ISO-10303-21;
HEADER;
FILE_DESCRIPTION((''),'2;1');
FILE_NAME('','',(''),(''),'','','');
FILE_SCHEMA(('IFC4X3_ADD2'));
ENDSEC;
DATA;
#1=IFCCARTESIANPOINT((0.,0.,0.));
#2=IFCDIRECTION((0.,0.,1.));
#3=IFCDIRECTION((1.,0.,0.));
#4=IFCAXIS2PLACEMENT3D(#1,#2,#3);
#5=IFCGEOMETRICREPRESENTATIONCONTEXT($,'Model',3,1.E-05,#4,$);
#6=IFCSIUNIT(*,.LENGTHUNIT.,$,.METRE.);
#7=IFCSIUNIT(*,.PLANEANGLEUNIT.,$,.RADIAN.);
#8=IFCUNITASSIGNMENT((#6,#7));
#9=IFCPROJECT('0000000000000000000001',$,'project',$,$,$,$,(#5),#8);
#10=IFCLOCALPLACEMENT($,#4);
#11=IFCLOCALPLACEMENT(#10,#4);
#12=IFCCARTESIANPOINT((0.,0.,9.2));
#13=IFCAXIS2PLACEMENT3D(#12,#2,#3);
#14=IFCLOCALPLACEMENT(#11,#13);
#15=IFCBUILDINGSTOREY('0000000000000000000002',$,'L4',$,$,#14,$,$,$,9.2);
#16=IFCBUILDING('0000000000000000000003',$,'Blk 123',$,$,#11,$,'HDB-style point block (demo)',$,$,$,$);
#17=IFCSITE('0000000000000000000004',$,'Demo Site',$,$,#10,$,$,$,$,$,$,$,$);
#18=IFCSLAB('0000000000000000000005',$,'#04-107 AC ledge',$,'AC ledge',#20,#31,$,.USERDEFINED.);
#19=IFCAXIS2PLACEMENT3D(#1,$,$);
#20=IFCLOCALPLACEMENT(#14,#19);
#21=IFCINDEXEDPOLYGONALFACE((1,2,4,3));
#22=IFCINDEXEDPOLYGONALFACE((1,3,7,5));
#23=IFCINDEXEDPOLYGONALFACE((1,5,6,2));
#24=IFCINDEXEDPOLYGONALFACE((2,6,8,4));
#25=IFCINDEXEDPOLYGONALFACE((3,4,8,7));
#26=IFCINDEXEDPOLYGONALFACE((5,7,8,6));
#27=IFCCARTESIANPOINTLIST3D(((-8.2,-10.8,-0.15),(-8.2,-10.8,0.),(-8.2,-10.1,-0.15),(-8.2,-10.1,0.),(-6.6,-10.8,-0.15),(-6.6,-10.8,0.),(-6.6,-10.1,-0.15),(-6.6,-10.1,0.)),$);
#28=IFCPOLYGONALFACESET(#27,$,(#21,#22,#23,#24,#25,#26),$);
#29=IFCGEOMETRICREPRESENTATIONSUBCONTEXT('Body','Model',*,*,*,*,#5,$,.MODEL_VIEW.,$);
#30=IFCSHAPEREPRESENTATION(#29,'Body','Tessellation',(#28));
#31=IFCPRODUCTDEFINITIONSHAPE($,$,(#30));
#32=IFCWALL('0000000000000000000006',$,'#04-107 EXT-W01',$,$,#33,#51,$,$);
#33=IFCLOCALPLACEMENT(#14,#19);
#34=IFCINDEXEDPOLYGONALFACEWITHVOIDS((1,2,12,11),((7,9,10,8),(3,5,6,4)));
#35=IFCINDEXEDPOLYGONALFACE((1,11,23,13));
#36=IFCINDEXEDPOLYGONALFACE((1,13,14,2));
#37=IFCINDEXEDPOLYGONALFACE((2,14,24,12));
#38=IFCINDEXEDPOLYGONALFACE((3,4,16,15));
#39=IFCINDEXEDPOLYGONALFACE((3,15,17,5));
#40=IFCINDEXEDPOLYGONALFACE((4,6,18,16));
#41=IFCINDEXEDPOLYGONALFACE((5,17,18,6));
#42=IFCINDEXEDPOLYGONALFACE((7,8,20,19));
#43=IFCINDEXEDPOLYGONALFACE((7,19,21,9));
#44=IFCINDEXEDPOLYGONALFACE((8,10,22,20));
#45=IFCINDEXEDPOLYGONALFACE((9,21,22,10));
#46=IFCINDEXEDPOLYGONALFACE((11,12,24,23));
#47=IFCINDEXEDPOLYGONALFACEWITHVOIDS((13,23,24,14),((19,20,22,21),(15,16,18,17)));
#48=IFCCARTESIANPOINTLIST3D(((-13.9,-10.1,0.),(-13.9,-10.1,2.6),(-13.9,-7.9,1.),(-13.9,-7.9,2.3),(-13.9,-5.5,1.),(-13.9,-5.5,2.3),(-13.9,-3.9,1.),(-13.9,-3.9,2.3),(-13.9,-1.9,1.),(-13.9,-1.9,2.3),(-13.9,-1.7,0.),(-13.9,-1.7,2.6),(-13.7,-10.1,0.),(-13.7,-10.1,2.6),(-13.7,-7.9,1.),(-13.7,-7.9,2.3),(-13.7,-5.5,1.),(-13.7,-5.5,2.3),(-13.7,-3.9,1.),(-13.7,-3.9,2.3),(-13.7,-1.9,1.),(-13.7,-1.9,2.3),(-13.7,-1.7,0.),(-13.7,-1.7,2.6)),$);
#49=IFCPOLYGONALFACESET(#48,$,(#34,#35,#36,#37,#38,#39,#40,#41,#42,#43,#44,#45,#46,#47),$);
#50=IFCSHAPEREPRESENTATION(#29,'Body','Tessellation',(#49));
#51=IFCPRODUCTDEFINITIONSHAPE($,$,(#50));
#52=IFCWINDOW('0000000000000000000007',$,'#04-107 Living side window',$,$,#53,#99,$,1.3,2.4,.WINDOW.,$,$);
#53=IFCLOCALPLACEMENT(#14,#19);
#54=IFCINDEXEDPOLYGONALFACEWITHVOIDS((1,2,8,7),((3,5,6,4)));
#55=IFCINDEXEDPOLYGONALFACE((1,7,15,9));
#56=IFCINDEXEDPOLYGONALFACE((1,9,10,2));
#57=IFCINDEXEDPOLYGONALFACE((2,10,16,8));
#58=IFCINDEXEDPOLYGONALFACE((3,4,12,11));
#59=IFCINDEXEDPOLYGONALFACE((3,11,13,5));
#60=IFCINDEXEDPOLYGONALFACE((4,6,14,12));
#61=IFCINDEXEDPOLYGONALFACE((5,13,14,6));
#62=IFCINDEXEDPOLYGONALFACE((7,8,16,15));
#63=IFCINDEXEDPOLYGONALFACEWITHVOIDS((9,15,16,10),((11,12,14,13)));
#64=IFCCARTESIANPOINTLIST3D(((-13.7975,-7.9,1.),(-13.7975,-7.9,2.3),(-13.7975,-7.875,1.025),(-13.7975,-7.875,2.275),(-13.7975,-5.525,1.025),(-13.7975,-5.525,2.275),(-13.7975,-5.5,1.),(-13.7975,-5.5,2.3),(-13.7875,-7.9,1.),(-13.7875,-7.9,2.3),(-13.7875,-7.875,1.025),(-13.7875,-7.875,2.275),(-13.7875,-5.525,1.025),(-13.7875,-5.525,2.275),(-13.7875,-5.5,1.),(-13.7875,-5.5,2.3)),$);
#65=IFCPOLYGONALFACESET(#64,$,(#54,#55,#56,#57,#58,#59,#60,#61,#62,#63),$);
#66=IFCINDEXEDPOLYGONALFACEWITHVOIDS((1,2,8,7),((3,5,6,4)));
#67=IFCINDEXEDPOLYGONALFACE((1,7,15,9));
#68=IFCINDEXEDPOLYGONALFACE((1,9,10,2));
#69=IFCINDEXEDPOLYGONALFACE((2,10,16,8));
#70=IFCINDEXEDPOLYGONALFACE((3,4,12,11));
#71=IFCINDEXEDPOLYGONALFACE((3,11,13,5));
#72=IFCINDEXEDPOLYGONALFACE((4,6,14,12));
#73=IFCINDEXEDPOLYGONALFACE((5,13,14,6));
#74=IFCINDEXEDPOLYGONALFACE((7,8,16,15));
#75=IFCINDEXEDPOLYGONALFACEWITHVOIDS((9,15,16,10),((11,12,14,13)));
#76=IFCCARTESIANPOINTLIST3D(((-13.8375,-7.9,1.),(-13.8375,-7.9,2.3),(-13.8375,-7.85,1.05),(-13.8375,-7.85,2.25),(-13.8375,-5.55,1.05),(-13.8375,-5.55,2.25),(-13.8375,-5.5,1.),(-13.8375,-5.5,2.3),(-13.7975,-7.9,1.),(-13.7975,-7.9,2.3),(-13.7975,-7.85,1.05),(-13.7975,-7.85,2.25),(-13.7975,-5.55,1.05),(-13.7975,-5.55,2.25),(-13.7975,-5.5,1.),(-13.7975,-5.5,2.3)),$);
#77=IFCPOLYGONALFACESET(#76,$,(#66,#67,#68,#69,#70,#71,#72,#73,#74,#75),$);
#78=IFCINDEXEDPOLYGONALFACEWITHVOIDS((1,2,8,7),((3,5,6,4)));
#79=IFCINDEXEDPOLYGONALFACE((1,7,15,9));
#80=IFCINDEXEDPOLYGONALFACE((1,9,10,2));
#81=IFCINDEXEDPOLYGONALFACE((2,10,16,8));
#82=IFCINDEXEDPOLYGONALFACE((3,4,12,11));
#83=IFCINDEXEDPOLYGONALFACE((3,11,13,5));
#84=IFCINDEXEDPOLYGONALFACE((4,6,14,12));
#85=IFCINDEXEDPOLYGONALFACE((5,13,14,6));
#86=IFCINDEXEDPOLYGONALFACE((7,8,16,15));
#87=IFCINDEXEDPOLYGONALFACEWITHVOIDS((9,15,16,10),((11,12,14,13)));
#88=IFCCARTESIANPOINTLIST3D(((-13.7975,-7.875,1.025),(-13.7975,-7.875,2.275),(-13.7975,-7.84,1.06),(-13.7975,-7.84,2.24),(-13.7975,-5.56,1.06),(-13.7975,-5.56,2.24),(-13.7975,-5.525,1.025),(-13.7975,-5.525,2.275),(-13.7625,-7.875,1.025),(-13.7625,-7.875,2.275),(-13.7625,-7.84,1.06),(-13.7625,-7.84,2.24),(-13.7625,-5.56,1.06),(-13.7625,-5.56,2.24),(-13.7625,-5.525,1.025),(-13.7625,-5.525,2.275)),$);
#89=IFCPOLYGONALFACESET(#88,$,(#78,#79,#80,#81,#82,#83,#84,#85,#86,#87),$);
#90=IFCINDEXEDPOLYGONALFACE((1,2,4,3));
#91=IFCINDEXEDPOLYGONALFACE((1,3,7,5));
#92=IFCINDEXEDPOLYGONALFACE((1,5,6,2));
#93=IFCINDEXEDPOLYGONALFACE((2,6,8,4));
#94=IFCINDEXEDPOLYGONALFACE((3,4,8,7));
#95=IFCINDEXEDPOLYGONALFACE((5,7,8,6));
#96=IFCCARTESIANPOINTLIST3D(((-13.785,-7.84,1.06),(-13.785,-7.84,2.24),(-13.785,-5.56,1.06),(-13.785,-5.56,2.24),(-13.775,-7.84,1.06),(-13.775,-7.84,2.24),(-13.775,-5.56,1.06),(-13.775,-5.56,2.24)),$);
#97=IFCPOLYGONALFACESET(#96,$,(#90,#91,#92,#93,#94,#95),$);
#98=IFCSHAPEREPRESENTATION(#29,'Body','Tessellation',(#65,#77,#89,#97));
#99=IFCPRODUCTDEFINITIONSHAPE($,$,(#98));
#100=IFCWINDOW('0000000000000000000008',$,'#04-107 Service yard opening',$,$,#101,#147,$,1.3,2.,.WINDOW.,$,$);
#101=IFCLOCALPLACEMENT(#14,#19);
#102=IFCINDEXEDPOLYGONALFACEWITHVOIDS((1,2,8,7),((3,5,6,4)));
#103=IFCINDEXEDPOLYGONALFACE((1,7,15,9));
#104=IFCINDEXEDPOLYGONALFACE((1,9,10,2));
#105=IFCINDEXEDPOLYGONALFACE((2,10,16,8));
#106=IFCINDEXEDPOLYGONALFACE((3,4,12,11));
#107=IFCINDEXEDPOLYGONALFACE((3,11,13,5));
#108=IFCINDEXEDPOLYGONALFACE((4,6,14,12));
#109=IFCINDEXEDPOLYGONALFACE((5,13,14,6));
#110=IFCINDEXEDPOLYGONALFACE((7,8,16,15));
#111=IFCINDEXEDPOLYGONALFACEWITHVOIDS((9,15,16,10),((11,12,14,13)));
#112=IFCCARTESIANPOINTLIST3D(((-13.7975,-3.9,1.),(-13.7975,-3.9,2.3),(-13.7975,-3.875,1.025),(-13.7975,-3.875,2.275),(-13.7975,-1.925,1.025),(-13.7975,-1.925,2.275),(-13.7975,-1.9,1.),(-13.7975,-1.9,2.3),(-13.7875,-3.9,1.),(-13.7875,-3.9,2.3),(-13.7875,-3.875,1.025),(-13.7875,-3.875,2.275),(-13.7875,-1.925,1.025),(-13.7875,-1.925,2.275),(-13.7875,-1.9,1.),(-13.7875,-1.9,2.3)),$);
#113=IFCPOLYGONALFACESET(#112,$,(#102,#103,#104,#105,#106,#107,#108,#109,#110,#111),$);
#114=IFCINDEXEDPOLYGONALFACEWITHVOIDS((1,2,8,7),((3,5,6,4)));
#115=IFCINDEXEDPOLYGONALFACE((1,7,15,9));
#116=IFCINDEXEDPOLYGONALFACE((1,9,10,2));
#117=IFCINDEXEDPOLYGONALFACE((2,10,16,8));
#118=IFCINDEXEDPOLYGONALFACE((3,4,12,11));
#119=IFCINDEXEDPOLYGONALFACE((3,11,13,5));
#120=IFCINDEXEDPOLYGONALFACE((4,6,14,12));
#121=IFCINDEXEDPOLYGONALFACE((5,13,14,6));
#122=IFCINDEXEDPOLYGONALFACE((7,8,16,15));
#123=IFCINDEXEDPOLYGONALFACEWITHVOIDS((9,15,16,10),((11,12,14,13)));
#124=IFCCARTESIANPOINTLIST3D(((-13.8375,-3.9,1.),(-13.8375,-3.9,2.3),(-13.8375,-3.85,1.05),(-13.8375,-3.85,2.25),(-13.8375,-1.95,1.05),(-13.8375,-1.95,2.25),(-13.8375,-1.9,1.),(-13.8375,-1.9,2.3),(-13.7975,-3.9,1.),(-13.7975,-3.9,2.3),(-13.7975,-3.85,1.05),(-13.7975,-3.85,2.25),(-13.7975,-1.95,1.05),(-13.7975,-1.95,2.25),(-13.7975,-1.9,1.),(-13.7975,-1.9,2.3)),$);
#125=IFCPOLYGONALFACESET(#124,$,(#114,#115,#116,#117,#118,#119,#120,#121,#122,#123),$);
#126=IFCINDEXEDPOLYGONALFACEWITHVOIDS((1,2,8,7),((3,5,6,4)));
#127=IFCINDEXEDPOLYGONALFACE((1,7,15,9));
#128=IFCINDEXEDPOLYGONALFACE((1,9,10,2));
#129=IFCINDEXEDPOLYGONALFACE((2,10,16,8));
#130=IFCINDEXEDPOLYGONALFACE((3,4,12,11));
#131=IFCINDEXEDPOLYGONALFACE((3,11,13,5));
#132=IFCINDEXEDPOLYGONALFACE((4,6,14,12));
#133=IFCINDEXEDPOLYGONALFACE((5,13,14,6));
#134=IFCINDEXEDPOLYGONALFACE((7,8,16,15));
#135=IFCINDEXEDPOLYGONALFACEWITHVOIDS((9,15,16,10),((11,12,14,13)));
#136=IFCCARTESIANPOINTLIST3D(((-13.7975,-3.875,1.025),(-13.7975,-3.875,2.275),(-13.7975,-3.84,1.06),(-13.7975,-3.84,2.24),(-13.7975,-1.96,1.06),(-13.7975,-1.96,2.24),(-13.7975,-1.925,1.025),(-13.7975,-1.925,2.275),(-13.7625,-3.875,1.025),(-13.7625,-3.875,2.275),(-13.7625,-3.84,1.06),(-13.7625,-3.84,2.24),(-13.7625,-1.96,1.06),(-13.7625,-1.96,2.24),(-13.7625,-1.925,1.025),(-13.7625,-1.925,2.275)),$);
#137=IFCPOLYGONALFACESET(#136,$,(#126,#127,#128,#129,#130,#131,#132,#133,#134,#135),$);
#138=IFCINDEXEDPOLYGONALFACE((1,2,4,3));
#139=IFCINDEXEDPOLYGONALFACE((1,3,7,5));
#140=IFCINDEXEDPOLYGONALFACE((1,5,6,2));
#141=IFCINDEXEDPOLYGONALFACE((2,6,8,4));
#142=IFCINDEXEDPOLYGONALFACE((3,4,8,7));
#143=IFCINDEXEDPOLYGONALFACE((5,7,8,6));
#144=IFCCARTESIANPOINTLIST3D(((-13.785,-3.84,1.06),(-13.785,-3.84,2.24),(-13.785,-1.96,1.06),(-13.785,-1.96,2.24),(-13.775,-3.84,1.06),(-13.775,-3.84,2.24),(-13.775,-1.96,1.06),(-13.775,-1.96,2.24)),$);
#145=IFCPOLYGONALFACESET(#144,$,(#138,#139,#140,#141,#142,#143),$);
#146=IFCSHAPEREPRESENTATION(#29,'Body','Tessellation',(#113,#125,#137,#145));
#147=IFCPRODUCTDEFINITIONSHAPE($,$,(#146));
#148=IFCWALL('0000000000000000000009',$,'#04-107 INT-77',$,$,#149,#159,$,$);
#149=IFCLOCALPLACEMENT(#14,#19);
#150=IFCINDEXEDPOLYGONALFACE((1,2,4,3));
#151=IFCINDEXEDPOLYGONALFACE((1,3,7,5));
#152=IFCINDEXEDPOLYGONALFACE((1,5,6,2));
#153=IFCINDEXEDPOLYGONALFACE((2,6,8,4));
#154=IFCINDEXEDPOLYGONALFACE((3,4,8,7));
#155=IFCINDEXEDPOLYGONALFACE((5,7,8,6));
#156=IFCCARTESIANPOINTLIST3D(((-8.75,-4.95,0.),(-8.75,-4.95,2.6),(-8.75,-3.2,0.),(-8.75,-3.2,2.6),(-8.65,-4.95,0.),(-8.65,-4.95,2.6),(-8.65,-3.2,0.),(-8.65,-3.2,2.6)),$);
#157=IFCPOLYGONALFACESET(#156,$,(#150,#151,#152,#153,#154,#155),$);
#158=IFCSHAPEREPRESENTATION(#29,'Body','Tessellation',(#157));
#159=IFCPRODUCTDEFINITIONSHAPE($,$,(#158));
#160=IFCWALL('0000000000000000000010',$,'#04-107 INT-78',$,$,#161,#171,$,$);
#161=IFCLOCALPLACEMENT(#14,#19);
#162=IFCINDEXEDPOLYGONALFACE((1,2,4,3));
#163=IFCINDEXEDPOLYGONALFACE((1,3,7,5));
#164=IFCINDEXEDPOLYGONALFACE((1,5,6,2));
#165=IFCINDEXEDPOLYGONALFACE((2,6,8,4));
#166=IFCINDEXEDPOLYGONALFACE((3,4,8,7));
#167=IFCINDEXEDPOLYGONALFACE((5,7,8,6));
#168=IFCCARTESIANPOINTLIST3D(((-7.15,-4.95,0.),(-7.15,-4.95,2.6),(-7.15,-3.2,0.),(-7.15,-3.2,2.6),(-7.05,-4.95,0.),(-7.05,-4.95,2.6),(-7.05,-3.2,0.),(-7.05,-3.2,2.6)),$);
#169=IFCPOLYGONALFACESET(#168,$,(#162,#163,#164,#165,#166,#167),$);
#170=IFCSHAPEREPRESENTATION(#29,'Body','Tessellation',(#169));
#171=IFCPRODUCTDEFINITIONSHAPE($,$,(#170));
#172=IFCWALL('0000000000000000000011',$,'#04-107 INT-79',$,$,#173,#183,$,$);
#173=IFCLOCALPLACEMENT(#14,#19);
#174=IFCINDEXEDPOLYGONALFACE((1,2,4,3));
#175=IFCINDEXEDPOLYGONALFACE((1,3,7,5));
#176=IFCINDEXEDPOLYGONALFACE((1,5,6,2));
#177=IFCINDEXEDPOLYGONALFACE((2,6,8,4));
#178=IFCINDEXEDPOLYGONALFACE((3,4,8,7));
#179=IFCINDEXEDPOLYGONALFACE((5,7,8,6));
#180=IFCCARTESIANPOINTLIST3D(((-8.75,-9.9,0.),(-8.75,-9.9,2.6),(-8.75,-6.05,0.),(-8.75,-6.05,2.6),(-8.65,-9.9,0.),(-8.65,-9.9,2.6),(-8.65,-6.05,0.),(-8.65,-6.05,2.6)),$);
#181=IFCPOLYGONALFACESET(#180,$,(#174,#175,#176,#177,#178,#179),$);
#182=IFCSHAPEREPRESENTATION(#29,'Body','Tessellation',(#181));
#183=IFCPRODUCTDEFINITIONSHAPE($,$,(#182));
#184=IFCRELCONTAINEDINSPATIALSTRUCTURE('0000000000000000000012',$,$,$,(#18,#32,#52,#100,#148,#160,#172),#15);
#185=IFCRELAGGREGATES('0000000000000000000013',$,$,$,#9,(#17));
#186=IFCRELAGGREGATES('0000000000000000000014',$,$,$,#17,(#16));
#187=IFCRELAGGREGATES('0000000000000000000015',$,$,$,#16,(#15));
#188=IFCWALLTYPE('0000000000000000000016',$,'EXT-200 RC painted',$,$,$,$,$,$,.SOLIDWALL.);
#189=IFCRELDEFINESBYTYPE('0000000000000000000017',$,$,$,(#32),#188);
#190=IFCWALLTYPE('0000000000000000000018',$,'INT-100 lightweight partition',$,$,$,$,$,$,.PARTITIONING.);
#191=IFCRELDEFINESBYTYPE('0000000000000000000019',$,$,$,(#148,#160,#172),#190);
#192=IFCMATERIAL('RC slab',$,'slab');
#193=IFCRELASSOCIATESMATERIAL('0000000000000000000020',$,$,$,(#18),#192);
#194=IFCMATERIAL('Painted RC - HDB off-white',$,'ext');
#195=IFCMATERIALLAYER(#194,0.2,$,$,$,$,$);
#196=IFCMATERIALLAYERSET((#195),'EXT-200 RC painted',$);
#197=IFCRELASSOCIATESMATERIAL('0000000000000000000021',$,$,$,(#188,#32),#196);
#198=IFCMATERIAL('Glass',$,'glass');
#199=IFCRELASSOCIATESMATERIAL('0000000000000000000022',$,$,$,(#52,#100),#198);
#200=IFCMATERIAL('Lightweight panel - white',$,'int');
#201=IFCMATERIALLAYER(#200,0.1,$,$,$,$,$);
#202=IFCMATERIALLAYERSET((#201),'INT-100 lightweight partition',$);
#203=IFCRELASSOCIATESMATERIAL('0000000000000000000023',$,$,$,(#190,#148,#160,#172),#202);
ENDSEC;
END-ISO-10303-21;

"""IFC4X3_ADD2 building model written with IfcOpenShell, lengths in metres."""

from ifc_helpers import new_model, si_unit, frame, origin, origin_with_axes, place, context, subcontext, project, spatial, polyline, line, indexed_curve, outline, extrude, material, layer, layer_set, layer_usage, type_object, element, fill, save


model = new_model("IFC4X3_ADD2")

# Units and contexts
model_context = context("Model", 3, precision=1e-05, world=origin_with_axes())
body_context = subcontext(model_context, "Body", "Model", "MODEL_VIEW")
ifc_project = project(units=[si_unit("LENGTHUNIT", "METRE"), si_unit("PLANEANGLEUNIT", "RADIAN")], contexts=[model_context])

# Site, building, storey
site_placement = place(None, origin_with_axes())
site = spatial("IfcSite", under=ifc_project, at=site_placement, Name="Demo Site")
building_placement = place(site_placement, origin_with_axes())
building = spatial("IfcBuilding", under=site, at=building_placement, Name="Blk 123", LongName="HDB-style point block (demo)")
storey_placement = place(building_placement, frame((0.0, 0.0, 9.2), z_axis=(0.0, 0.0, 1.0), x_axis=(1.0, 0.0, 0.0)))
storey = spatial("IfcBuildingStorey", under=building, at=storey_placement, Name="L4", Elevation=9.2)

# Slab
ifc_material_1 = material(Name="RC slab", Category="slab")
slab_placement = place(storey_placement, frame((-7.4, -10.45, -0.15), z_axis=(0.0, 0.0, 1.0), x_axis=(1.0, 0.0, 0.0)))
element("IfcSlab", 1, at=slab_placement, inside=storey, material=ifc_material_1, Name="#04-107 AC ledge", ObjectType="AC ledge", PredefinedType="USERDEFINED", context=body_context, shape_type="SweptSolid", body=[
    extrude(outline(polyline([(-0.8, 0.35), (-0.8, -0.35), (0.8, -0.35), (0.8, 0.35), (-0.8, 0.35)])), origin(), (0.0, 0.0, 1.0), 0.15),
])

# Wall, openings, windows
ifc_material_2 = material(Name="Painted RC - HDB off-white", Category="ext")
ifc_layer_1 = layer(ifc_material_2, 0.2)
ifc_layer_set_1 = layer_set([ifc_layer_1], Name="EXT-200 RC painted")
ifc_layer_usage_1 = layer_usage(ifc_layer_set_1, "AXIS2", "POSITIVE", 0.0)
wall_type_1 = type_object("IfcWallType", Name="EXT-200 RC painted", PredefinedType="SOLIDWALL", material=ifc_layer_set_1)
wall_1_placement = place(storey_placement, frame((-13.9, -1.7, 0.0), z_axis=(0.0, 0.0, 1.0), x_axis=(0.0, -1.0, 0.0)))
wall_1 = element("IfcWall", 2, at=wall_1_placement, inside=storey, type_object=wall_type_1, material=ifc_layer_usage_1, Name="#04-107 EXT-W01", context=body_context, shape_type="SweptSolid", body=[
    extrude(outline(indexed_curve([(0.0, 0.0), (0.0, 0.2), (8.4, 0.2), (8.4, 0.0), (0.0, 0.0)], self_intersect=False)), origin_with_axes(), (0.0, 0.0, 1.0), 2.6),
])
opening_1_placement = place(wall_1_placement, frame((3.8, -0.1, 1.0), z_axis=(0.0, 0.0, 1.0), x_axis=(1.0, 0.0, 0.0)))
opening_1 = element("IfcOpeningElement", 3, at=opening_1_placement, cuts=wall_1, context=body_context, shape_type="SweptSolid", body=[
    extrude(outline(indexed_curve([(0.0, 0.0), (0.0, 0.4), (2.4, 0.4), (2.4, 0.0), (0.0, 0.0)], self_intersect=False)), origin_with_axes(), (0.0, 0.0, 1.0), 1.3),
])
opening_2_placement = place(wall_1_placement, frame((0.2, -0.1, 1.0), z_axis=(0.0, 0.0, 1.0), x_axis=(1.0, 0.0, 0.0)))
opening_2 = element("IfcOpeningElement", 4, at=opening_2_placement, cuts=wall_1, context=body_context, shape_type="SweptSolid", body=[
    extrude(outline(indexed_curve([(0.0, 0.0), (0.0, 0.4), (2.0, 0.4), (2.0, 0.0), (0.0, 0.0)], self_intersect=False)), origin_with_axes(), (0.0, 0.0, 1.0), 1.3),
])
ifc_material_3 = material(Name="Glass", Category="glass")
window_1_placement = place(opening_1_placement, frame((0.0, 0.1125, 0.0), z_axis=(0.0, 0.0, 1.0), x_axis=(1.0, 0.0, 0.0)))
window_1 = element("IfcWindow", 5, at=window_1_placement, inside=storey, material=ifc_material_3, Name="#04-107 Living side window", OverallHeight=1.3, OverallWidth=2.4, PredefinedType="WINDOW", context=body_context, shape_type="SweptSolid", body=[
    extrude(outline(indexed_curve([(0.0, 0.0), (2.4, 0.0), (2.4, 1.3), (0.0, 1.3)], segments=[line(1, 2, 3, 4, 1)]), holes=[indexed_curve([(0.025, 0.025), (2.375, 0.025), (2.375, 1.275), (0.025, 1.275)], segments=[line(1, 2, 3, 4, 1)])]), frame((0.0, 0.09, 0.0), z_axis=(0.0, -1.0, 0.0), x_axis=(1.0, 0.0, 0.0)), (0.0, 0.0, -1.0), 0.01),
    extrude(outline(indexed_curve([(0.0, 0.0), (2.4, 0.0), (2.4, 1.3), (0.0, 1.3)], segments=[line(1, 2, 3, 4, 1)]), holes=[indexed_curve([(0.05, 0.05), (2.35, 0.05), (2.35, 1.25), (0.05, 1.25)], segments=[line(1, 2, 3, 4, 1)])]), frame((0.0, 0.05, 0.0), z_axis=(0.0, -1.0, 0.0), x_axis=(1.0, 0.0, 0.0)), (0.0, 0.0, -1.0), 0.04),
    extrude(outline(indexed_curve([(0.0, 0.0), (2.35, 0.0), (2.35, 1.25), (0.0, 1.25)], segments=[line(1, 2, 3, 4, 1)]), holes=[indexed_curve([(0.035, 0.035), (2.315, 0.035), (2.315, 1.215), (0.035, 1.215)], segments=[line(1, 2, 3, 4, 1)])]), frame((0.025, 0.09, 0.025), z_axis=(0.0, -1.0, 0.0), x_axis=(1.0, 0.0, 0.0)), (0.0, 0.0, -1.0), 0.035),
    extrude(outline(indexed_curve([(0.035, 0.035), (2.315, 0.035), (2.315, 1.215), (0.035, 1.215)], segments=[line(1, 2, 3, 4, 1)])), frame((0.025, 0.1025, 0.025), z_axis=(0.0, -1.0, 0.0), x_axis=(1.0, 0.0, 0.0)), (0.0, 0.0, -1.0), 0.01),
])
fill(opening_1, window_1)
window_2_placement = place(opening_2_placement, frame((0.0, 0.1125, 0.0), z_axis=(0.0, 0.0, 1.0), x_axis=(1.0, 0.0, 0.0)))
window_2 = element("IfcWindow", 6, at=window_2_placement, inside=storey, material=ifc_material_3, Name="#04-107 Service yard opening", OverallHeight=1.3, OverallWidth=2.0, PredefinedType="WINDOW", context=body_context, shape_type="SweptSolid", body=[
    extrude(outline(indexed_curve([(0.0, 0.0), (2.0, 0.0), (2.0, 1.3), (0.0, 1.3)], segments=[line(1, 2, 3, 4, 1)]), holes=[indexed_curve([(0.025, 0.025), (1.975, 0.025), (1.975, 1.275), (0.025, 1.275)], segments=[line(1, 2, 3, 4, 1)])]), frame((0.0, 0.09, 0.0), z_axis=(0.0, -1.0, 0.0), x_axis=(1.0, 0.0, 0.0)), (0.0, 0.0, -1.0), 0.01),
    extrude(outline(indexed_curve([(0.0, 0.0), (2.0, 0.0), (2.0, 1.3), (0.0, 1.3)], segments=[line(1, 2, 3, 4, 1)]), holes=[indexed_curve([(0.05, 0.05), (1.95, 0.05), (1.95, 1.25), (0.05, 1.25)], segments=[line(1, 2, 3, 4, 1)])]), frame((0.0, 0.05, 0.0), z_axis=(0.0, -1.0, 0.0), x_axis=(1.0, 0.0, 0.0)), (0.0, 0.0, -1.0), 0.04),
    extrude(outline(indexed_curve([(0.0, 0.0), (1.95, 0.0), (1.95, 1.25), (0.0, 1.25)], segments=[line(1, 2, 3, 4, 1)]), holes=[indexed_curve([(0.035, 0.035), (1.915, 0.035), (1.915, 1.215), (0.035, 1.215)], segments=[line(1, 2, 3, 4, 1)])]), frame((0.025, 0.09, 0.025), z_axis=(0.0, -1.0, 0.0), x_axis=(1.0, 0.0, 0.0)), (0.0, 0.0, -1.0), 0.035),
    extrude(outline(indexed_curve([(0.035, 0.035), (1.915, 0.035), (1.915, 1.215), (0.035, 1.215)], segments=[line(1, 2, 3, 4, 1)])), frame((0.025, 0.1025, 0.025), z_axis=(0.0, -1.0, 0.0), x_axis=(1.0, 0.0, 0.0)), (0.0, 0.0, -1.0), 0.01),
])
fill(opening_2, window_2)

# Walls
ifc_material_4 = material(Name="Lightweight panel - white", Category="int")
ifc_layer_2 = layer(ifc_material_4, 0.1)
ifc_layer_set_2 = layer_set([ifc_layer_2], Name="INT-100 lightweight partition")
ifc_layer_usage_2 = layer_usage(ifc_layer_set_2, "AXIS2", "POSITIVE", -0.05)
wall_type_2 = type_object("IfcWallType", Name="INT-100 lightweight partition", PredefinedType="PARTITIONING", material=ifc_layer_set_2)
for number, where, z_axis, x_axis, name in (
    (7, (-8.7, -3.2, 0.0), (0.0, 0.0, 1.0), (0.0, -1.0, 0.0), "#04-107 INT-77"),
    (8, (-7.1, -3.2, 0.0), (0.0, 0.0, 1.0), (0.0, -1.0, 0.0), "#04-107 INT-78"),
):
    element("IfcWall", number, at=place(storey_placement, frame(where, z_axis=z_axis, x_axis=x_axis)), inside=storey, type_object=wall_type_2, material=ifc_layer_usage_2, Name=name, context=body_context, shape_type="SweptSolid", body=[
        extrude(outline(indexed_curve([(0.0, 0.0), (0.0, 0.1), (1.75, 0.1), (1.75, 0.0), (0.0, 0.0)], self_intersect=False)), frame((0.0, -0.05, 0.0), z_axis=(0.0, 0.0, 1.0), x_axis=(1.0, 0.0, 0.0)), (0.0, 0.0, 1.0), 2.6),
    ])
wall_2_placement = place(storey_placement, frame((-8.7, -6.05, 0.0), z_axis=(0.0, 0.0, 1.0), x_axis=(0.0, -1.0, 0.0)))
element("IfcWall", 9, at=wall_2_placement, inside=storey, type_object=wall_type_2, material=ifc_layer_usage_2, Name="#04-107 INT-79", context=body_context, shape_type="SweptSolid", body=[
    extrude(outline(indexed_curve([(0.0, 0.0), (0.0, 0.1), (3.85, 0.1), (3.85, 0.0), (0.0, 0.0)], self_intersect=False)), frame((0.0, -0.05, 0.0), z_axis=(0.0, 0.0, 1.0), x_axis=(1.0, 0.0, 0.0)), (0.0, 0.0, 1.0), 2.6),
])

save(model, "model.ifc")
